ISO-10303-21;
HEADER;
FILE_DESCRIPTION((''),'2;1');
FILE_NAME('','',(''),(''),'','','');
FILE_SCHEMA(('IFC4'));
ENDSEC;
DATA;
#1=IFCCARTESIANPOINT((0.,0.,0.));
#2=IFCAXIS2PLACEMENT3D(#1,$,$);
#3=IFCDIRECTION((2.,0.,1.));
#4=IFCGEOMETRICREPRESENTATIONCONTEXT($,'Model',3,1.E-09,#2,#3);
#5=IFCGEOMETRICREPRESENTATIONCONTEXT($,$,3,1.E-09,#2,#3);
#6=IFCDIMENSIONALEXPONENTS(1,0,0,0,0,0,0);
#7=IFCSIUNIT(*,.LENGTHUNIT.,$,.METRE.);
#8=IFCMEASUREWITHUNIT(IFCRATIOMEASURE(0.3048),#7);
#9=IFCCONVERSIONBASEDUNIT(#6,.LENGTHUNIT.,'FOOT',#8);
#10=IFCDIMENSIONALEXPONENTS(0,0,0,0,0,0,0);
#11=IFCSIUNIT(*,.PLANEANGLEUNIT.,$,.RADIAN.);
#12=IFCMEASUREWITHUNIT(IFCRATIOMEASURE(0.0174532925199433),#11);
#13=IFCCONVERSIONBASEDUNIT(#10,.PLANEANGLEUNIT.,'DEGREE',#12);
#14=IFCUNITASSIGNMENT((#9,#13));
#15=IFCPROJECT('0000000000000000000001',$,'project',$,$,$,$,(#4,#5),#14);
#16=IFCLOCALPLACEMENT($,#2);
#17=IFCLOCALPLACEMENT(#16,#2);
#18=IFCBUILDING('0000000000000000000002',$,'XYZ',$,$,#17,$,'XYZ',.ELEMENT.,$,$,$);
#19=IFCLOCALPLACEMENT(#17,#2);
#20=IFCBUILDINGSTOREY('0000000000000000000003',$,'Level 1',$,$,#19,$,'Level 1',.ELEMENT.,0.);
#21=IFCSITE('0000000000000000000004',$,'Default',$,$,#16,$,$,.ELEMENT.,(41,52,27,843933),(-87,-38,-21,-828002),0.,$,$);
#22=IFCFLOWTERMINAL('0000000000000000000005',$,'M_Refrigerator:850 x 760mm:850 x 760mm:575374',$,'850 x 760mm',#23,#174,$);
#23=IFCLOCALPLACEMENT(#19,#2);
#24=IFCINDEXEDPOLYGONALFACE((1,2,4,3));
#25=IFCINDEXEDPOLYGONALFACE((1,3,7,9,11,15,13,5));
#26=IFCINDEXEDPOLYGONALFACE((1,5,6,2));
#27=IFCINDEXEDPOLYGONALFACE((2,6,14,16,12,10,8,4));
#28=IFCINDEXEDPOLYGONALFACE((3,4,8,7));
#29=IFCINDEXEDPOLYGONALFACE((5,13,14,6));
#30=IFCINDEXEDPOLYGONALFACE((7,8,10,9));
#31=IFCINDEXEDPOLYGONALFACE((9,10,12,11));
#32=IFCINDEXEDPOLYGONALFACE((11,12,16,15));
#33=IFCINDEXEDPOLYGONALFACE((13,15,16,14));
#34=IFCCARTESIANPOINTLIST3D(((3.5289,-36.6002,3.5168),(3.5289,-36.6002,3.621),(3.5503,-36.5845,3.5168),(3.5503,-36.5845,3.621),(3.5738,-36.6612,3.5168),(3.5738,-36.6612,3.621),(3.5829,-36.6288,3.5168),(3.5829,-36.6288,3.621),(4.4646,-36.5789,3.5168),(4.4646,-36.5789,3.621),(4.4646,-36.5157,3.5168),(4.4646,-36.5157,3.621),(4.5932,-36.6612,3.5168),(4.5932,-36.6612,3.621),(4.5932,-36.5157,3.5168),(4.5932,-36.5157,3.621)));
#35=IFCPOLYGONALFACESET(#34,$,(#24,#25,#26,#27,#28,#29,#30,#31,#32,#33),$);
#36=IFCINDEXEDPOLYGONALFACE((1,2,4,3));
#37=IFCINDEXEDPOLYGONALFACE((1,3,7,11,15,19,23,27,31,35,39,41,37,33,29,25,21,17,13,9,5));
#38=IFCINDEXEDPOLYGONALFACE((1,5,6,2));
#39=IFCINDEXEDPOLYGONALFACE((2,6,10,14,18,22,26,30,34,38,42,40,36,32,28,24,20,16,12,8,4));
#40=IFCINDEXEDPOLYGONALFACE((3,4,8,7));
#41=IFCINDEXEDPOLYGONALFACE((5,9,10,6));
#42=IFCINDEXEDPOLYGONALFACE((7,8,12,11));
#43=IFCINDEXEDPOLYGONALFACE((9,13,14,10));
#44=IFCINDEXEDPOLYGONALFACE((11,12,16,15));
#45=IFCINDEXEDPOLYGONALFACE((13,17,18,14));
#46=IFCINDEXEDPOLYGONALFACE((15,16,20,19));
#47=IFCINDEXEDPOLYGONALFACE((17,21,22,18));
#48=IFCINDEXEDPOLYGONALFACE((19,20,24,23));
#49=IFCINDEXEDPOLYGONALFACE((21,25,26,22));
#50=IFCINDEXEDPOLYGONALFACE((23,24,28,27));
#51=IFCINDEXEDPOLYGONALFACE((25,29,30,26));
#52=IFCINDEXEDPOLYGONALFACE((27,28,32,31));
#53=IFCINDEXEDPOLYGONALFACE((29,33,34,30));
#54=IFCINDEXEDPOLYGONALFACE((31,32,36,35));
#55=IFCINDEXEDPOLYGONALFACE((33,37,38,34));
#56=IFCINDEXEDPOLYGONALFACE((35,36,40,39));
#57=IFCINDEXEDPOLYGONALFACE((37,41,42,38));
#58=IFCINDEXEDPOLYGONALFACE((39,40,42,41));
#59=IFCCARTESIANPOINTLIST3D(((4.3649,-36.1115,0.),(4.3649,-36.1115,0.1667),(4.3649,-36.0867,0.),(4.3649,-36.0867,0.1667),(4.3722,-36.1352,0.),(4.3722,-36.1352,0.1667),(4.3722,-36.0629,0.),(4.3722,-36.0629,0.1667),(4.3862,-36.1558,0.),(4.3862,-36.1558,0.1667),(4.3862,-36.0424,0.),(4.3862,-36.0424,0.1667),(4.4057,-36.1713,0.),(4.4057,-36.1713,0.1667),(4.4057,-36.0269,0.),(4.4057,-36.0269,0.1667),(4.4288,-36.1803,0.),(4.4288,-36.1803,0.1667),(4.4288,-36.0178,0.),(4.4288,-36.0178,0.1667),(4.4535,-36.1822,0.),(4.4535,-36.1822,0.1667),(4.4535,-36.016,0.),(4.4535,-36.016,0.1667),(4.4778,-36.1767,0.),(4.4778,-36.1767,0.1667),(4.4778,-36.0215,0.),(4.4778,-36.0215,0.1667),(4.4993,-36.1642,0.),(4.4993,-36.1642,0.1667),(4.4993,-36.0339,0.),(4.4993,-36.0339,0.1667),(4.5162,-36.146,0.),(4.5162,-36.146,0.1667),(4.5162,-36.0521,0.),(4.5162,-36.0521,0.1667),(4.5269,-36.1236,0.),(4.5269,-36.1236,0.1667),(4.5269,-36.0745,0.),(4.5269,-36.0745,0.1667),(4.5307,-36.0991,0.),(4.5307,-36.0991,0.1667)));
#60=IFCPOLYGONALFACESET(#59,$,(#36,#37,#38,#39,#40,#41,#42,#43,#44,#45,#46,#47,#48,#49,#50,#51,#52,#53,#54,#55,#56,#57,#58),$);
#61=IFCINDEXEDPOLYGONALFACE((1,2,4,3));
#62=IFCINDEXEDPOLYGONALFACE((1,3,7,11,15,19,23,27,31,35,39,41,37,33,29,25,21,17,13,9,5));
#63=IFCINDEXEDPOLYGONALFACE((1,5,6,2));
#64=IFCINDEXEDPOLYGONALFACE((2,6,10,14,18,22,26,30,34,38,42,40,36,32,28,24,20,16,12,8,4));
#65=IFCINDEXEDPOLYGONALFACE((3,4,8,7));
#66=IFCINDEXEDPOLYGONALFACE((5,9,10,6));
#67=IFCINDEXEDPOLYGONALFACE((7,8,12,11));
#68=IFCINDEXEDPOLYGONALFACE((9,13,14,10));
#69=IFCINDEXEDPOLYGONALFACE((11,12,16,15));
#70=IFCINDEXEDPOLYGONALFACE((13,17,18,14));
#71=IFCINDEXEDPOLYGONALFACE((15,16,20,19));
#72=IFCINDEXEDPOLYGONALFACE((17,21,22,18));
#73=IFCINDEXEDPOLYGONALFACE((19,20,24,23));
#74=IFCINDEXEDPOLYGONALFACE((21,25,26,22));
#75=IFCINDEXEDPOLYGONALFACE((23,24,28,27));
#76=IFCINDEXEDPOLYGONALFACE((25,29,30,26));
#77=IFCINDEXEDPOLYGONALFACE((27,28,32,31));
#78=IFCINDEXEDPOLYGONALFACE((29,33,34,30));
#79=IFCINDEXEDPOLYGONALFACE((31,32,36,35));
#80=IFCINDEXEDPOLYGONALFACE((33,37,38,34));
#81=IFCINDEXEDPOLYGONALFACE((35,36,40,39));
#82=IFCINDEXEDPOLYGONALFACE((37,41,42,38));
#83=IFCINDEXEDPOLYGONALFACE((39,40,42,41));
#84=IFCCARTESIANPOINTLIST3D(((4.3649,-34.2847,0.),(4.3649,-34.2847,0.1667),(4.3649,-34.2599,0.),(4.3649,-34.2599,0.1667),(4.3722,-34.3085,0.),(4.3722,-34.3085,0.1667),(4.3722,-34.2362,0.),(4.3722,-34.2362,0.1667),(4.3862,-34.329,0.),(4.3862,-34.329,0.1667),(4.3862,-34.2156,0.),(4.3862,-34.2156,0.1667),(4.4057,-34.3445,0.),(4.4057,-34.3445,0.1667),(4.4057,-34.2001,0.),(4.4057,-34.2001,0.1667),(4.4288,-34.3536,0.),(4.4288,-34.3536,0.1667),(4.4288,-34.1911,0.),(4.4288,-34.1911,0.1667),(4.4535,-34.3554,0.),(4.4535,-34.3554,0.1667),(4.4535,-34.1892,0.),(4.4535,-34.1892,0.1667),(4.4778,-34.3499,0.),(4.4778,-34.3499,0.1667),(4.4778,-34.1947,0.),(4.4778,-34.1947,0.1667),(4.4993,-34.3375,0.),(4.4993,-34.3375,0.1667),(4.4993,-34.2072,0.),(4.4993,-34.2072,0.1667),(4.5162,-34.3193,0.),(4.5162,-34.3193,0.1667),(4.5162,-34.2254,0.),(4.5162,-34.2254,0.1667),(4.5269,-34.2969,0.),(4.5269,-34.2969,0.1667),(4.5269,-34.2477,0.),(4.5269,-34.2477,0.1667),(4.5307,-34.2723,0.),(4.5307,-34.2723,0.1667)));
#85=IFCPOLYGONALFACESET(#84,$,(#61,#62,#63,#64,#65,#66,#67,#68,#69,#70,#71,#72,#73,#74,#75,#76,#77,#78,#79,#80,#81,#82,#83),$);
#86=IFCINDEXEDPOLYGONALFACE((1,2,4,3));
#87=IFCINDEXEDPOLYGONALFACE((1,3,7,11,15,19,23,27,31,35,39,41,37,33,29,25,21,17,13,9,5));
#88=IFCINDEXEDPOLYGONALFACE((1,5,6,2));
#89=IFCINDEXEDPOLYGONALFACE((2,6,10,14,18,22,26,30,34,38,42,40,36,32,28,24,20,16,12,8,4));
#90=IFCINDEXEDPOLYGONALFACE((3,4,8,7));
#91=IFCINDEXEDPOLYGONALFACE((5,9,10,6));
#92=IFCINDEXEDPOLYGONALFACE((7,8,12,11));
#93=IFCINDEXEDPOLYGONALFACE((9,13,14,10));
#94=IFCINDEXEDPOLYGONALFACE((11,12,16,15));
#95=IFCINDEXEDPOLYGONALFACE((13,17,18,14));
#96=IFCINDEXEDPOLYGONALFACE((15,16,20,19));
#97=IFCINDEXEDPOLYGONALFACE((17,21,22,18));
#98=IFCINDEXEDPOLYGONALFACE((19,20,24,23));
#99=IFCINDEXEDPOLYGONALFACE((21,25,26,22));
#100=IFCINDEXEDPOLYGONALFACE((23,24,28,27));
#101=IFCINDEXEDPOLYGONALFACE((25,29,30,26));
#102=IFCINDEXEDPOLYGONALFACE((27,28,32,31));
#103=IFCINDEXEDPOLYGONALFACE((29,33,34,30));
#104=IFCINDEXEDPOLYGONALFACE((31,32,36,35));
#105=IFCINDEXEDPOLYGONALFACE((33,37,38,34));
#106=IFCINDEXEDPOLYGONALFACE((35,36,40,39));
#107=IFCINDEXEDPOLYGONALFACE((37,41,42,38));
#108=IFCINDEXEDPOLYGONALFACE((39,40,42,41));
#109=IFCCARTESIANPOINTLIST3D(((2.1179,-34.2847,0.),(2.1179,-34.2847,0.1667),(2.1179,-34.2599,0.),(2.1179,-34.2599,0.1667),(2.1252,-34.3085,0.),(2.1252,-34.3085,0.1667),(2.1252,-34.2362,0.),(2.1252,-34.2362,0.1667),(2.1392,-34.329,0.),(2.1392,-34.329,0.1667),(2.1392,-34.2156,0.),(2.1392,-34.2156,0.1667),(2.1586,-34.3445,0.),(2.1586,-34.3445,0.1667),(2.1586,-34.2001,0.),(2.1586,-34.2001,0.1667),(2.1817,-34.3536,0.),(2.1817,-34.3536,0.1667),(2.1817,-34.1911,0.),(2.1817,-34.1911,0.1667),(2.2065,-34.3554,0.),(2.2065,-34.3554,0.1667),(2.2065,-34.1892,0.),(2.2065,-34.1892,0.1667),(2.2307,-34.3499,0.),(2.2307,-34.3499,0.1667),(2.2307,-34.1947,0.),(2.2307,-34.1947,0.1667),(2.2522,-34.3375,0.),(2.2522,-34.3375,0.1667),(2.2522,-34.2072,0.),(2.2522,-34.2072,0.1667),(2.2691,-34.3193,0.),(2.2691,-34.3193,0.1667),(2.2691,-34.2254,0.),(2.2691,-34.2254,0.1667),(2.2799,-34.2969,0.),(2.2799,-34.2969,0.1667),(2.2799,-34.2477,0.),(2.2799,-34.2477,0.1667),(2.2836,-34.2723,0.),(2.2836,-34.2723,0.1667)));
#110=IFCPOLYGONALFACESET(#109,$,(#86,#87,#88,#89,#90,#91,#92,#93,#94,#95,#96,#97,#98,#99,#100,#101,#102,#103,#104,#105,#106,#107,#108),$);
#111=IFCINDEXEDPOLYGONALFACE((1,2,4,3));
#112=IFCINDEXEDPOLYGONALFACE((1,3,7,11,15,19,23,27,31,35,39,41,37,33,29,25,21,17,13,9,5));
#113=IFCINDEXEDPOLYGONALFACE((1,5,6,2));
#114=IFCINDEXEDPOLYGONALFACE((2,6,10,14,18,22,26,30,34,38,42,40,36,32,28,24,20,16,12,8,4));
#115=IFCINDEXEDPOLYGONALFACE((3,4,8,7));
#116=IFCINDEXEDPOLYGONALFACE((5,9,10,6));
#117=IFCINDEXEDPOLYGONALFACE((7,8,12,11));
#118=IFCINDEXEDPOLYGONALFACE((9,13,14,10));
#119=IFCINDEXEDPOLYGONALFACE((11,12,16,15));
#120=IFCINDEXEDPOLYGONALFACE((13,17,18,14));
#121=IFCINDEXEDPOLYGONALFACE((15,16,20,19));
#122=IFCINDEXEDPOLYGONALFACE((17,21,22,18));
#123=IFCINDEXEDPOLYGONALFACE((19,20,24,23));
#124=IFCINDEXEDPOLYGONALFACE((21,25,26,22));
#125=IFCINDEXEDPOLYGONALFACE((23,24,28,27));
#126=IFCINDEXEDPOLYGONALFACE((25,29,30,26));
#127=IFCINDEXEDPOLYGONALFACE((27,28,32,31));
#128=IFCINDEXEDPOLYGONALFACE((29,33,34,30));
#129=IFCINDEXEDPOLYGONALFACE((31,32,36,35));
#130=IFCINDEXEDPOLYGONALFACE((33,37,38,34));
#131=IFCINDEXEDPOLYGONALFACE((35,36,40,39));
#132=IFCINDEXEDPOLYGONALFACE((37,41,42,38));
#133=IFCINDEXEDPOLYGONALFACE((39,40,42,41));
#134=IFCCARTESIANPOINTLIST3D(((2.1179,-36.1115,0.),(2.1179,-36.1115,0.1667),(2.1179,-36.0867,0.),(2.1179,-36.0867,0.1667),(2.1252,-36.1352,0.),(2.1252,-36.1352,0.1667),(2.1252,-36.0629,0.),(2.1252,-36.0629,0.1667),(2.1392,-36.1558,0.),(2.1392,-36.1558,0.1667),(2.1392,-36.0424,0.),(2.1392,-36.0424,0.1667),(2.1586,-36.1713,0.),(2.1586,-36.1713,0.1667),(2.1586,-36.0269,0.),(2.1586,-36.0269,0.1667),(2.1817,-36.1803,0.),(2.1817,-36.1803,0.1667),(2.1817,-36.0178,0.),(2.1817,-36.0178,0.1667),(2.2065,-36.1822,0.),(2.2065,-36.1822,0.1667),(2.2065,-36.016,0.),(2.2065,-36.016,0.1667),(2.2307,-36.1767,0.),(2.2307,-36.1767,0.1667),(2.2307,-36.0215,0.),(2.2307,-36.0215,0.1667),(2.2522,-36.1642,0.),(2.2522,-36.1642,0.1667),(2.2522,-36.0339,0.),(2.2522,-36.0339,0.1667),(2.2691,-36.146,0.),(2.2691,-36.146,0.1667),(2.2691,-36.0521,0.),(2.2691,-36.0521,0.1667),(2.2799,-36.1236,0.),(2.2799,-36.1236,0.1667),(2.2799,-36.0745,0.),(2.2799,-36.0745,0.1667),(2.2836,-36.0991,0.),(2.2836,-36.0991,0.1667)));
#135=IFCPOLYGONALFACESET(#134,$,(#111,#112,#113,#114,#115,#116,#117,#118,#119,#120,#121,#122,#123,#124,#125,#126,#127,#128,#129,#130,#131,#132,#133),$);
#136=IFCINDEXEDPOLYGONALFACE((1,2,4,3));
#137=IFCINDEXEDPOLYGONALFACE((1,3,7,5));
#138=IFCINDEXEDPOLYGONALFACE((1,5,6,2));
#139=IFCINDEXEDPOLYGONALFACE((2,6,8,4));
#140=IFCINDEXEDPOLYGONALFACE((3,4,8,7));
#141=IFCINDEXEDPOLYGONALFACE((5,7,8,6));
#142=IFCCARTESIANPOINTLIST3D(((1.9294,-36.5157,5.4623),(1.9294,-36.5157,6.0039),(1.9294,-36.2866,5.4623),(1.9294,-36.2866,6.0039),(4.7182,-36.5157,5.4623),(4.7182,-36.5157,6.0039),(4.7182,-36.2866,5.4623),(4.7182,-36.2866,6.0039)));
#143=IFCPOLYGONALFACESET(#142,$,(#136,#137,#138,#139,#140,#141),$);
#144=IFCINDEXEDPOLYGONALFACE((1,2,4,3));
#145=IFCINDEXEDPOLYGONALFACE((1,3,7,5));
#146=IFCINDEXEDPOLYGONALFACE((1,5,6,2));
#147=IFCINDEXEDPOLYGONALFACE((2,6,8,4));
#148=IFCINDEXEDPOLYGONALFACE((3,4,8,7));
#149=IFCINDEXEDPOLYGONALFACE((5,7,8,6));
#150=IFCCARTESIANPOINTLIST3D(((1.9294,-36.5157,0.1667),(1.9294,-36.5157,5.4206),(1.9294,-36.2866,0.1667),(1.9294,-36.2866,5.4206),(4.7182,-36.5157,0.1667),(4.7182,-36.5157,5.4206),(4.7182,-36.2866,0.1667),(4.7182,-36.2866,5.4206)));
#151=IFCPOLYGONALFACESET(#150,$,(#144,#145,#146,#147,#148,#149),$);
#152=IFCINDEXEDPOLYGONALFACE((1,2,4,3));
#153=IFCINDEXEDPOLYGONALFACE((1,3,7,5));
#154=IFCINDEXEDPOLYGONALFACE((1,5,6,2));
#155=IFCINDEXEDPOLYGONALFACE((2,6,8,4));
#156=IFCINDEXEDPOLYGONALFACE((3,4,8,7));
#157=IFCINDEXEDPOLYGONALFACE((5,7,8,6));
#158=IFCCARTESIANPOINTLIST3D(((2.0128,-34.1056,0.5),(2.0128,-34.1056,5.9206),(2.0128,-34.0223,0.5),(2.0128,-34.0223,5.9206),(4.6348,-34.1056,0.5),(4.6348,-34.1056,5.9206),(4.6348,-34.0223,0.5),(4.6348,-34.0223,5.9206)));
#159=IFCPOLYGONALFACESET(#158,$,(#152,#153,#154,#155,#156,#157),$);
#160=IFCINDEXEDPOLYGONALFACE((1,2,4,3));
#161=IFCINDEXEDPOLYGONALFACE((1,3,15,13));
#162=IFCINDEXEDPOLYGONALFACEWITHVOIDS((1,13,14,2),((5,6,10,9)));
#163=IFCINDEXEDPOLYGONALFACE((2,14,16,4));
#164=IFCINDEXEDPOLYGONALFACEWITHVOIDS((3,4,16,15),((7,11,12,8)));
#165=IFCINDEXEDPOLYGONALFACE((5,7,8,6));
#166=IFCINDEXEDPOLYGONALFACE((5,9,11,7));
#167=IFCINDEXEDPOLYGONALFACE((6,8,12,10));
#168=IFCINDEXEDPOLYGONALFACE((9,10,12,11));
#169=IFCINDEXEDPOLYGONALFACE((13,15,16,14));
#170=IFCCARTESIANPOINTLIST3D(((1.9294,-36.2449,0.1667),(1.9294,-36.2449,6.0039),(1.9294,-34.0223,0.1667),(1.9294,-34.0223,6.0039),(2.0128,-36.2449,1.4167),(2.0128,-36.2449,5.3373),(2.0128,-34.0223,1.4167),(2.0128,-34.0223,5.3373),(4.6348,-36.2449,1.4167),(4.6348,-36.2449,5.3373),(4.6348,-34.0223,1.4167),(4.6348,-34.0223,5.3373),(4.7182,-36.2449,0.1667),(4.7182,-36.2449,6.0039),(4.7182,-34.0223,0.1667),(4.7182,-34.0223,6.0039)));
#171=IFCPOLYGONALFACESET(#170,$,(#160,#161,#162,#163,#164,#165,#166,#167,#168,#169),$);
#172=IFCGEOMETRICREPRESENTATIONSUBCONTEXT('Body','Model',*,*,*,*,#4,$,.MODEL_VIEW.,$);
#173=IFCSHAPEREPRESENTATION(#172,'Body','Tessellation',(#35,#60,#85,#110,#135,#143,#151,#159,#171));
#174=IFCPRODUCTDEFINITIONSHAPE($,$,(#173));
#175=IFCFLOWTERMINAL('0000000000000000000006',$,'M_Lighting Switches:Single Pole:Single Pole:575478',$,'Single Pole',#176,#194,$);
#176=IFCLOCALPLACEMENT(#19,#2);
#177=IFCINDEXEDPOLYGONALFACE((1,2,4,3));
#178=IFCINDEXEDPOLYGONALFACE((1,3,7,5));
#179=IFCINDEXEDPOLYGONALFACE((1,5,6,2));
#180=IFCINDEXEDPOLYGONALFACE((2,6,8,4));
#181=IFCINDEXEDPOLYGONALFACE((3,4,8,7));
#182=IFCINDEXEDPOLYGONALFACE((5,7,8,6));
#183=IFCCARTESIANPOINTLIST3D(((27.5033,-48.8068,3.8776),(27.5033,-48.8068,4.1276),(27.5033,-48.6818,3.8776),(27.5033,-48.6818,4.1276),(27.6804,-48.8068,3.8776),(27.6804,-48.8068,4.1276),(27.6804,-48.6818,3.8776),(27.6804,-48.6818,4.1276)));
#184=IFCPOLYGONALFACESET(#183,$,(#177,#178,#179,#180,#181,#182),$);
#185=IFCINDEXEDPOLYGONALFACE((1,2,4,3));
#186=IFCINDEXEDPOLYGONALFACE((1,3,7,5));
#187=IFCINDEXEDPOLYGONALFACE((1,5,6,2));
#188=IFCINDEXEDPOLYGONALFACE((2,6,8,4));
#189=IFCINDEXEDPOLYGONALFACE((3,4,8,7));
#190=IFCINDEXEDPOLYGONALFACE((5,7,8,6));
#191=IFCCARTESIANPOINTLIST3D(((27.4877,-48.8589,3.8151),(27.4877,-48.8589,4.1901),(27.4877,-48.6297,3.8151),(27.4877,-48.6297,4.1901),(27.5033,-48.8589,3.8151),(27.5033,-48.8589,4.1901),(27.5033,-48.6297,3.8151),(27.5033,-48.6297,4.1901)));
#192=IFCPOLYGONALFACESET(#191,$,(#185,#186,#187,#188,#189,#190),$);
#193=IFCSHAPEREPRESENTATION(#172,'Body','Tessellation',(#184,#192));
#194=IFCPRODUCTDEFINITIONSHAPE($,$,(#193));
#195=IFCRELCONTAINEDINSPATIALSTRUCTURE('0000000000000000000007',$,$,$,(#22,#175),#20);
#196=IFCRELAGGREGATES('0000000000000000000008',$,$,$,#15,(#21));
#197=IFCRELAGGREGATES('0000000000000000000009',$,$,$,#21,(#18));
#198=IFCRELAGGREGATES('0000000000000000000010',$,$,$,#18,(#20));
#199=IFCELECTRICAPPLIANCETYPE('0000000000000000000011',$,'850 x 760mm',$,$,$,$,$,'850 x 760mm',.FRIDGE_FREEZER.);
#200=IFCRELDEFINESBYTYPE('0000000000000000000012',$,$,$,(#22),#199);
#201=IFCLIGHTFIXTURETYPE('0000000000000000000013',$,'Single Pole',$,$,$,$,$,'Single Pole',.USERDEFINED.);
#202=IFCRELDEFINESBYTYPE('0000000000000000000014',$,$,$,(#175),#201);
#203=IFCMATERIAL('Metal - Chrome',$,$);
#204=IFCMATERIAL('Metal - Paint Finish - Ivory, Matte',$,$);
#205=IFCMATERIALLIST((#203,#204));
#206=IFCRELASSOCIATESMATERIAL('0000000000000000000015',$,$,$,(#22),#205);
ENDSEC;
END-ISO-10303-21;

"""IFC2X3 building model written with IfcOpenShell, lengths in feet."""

from ifc_helpers import new_model, entity, si_unit, converted_unit, direction, frame, frame_2d, origin, origin_2d_with_axis, place, context, subcontext, project, spatial, polyline, rectangle, circle, outline, extrude, source, transform, mapped, material, material_list, type_object, type_shapes, element, save


model = new_model("IFC2X3")

# Units and contexts
model_context = context("Model", 3, precision=1e-09, world=origin(), true_north=direction((2.0, 0.0, 1.0)))
context_of_model = context(None, 3, precision=1e-09, world=origin(), true_north=direction((2.0, 0.0, 1.0)))
body_context = subcontext(model_context, "Body", "Model", "MODEL_VIEW")
ifc_project = project(units=[converted_unit("LENGTHUNIT", "FOOT", entity("IfcRatioMeasure", 0.3048), si_unit("LENGTHUNIT", "METRE"), dimensions=[1, 0, 0, 0, 0, 0, 0]), converted_unit("PLANEANGLEUNIT", "DEGREE", entity("IfcRatioMeasure", 0.0174532925199433), si_unit("PLANEANGLEUNIT", "RADIAN"), dimensions=[0, 0, 0, 0, 0, 0, 0])], contexts=[model_context, context_of_model])

# Site, building, storey
site_placement = place(None, origin())
site = spatial("IfcSite", under=ifc_project, at=site_placement, Name="Default", CompositionType="ELEMENT", RefLatitude=(41, 52, 27, 843933), RefLongitude=(-87, -38, -21, -828002), RefElevation=0.0)
building_placement = place(site_placement, origin())
building = spatial("IfcBuilding", under=site, at=building_placement, Name="XYZ", LongName="XYZ", CompositionType="ELEMENT")
storey_placement = place(building_placement, origin())
storey = spatial("IfcBuildingStorey", under=building, at=storey_placement, Name="Level 1", LongName="Level 1", CompositionType="ELEMENT", Elevation=0.0)

# Flow terminals
ifc_material_1 = material(Name="Metal - Chrome")
ifc_material_2 = material(Name="Metal - Paint Finish - Ivory, Matte")
ifc_material_list = material_list([ifc_material_1, ifc_material_2])
electric_appliance_type = type_object("IfcElectricApplianceType", Name="850 x 760mm", ElementType="850 x 760mm", PredefinedType="FRIDGE_FREEZER")
shared_shape_1 = source(origin(), body_context, "Body", "SweptSolid", [
    extrude(outline(polyline([(-0.0679, -0.5492), (0.0775, -0.5492), (0.0775, -0.4207), (0.0144, -0.4207), (-0.0355, 0.461), (0.0088, 0.4937), (-0.0069, 0.515), (-0.0679, 0.4701), (-0.0679, -0.5492)])), frame((0.5436, -1.4351, 3.5168), z_axis=(0.0, 0.0, 1.0), x_axis=(0.0, 1.0, 0.0)), (0.0, 0.0, 1.0), 0.1042),
    extrude(circle(Radius=0.0833, at=frame_2d((0.0, 0.0), x_axis=(1.0, 0.0))), frame((0.947, -0.9409, 0.0)), (0.0, 0.0, 1.0), 0.1667),
    extrude(circle(Radius=0.0833, at=frame_2d((0.0, 0.0), x_axis=(1.0, 0.0))), frame((0.947, 0.8859, 0.0)), (0.0, 0.0, 1.0), 0.1667),
    extrude(circle(Radius=0.0833, at=frame_2d((0.0, 0.0), x_axis=(1.0, 0.0))), frame((-1.3, 0.8859, 0.0)), (0.0, 0.0, 1.0), 0.1667),
    extrude(circle(Radius=0.0833, at=frame_2d((0.0, 0.0), x_axis=(1.0, 0.0))), frame((-1.3, -0.9409, 0.0)), (0.0, 0.0, 1.0), 0.1667),
    extrude(rectangle(XDim=0.2292, YDim=2.7887, at=frame_2d((0.0, 0.0), x_axis=(1.0, 0.0))), frame((-0.1765, -1.243, 5.4623), z_axis=(0.0, 0.0, 1.0), x_axis=(0.0, 1.0, 0.0)), (0.0, 0.0, 1.0), 0.5417),
    extrude(rectangle(XDim=0.2292, YDim=2.7887, at=frame_2d((0.0, 0.0), x_axis=(1.0, 0.0))), frame((-0.1765, -1.243, 0.1667), z_axis=(0.0, 0.0, 1.0), x_axis=(0.0, 1.0, 0.0)), (0.0, 0.0, 1.0), 5.2539),
    extrude(rectangle(XDim=0.0833, YDim=2.622, at=frame_2d((0.0, 0.0), x_axis=(1.0, 0.0))), frame((-0.1765, 1.0942, 0.5), z_axis=(0.0, 0.0, 1.0), x_axis=(0.0, 1.0, 0.0)), (0.0, 0.0, 1.0), 5.4206),
    extrude(outline(polyline([(-2.9186, -1.3944), (2.9186, -1.3944), (2.9186, 1.3944), (-2.9186, 1.3944), (-2.9186, -1.3944)]), holes=[polyline([(-2.252, -1.311), (-2.252, 1.311), (1.6686, 1.311), (1.6686, -1.311), (-2.252, -1.311)])]), frame((-0.1765, -1.0867, 3.0853), z_axis=(0.0, 1.0, 0.0), x_axis=(0.0, 0.0, -1.0)), (0.0, 0.0, 1.0), 2.2226),
])
type_shapes(electric_appliance_type, [shared_shape_1])
flow_terminal_placement = place(storey_placement, frame((3.5003, -35.1582, 0.0)))
element("IfcFlowTerminal", 1, at=flow_terminal_placement, inside=storey, type_object=electric_appliance_type, material=ifc_material_list, Name="M_Refrigerator:850 x 760mm:850 x 760mm:575374", ObjectType="850 x 760mm", context=body_context, shape_type="MappedRepresentation", body=[
    mapped(shared_shape_1, transform((0.0, 0.0, 0.0), scale=1.0)),
])
light_fixture_type = type_object("IfcLightFixtureType", Name="Single Pole", ElementType="Single Pole", PredefinedType="USERDEFINED")
shared_shape_2 = source(origin(), body_context, "Body", "SweptSolid", [
    extrude(rectangle(XDim=0.125, YDim=0.25, at=origin_2d_with_axis()), frame((0.0, 0.0, -0.1771), z_axis=(0.0, 0.0, 1.0), x_axis=(-1.0, 0.0, 0.0)), (0.0, 0.0, 1.0), 0.1771),
    extrude(rectangle(XDim=0.2292, YDim=0.375, at=frame_2d((0.0, 0.0), x_axis=(1.0, 0.0))), frame((0.0, 0.0, 0.0), z_axis=(0.0, 0.0, 1.0), x_axis=(-1.0, 0.0, 0.0)), (0.0, 0.0, 1.0), 0.0156),
])
type_shapes(light_fixture_type, [shared_shape_2])
for number, where, z_axis, x_axis, name in (
    (2, (27.5033, -48.7443, 4.0026), (-1.0, 0.0, 0.0), (0.0, -1.0, 0.0), "M_Lighting Switches:Single Pole:Single Pole:575478"),
):
    element("IfcFlowTerminal", number, at=place(storey_placement, frame(where, z_axis=z_axis, x_axis=x_axis)), inside=storey, type_object=light_fixture_type, Name=name, ObjectType="Single Pole", context=body_context, shape_type="MappedRepresentation", body=[
        mapped(shared_shape_2, transform((0.0, 0.0, 0.0), scale=1.0)),
    ])

save(model, "model.ifc")
